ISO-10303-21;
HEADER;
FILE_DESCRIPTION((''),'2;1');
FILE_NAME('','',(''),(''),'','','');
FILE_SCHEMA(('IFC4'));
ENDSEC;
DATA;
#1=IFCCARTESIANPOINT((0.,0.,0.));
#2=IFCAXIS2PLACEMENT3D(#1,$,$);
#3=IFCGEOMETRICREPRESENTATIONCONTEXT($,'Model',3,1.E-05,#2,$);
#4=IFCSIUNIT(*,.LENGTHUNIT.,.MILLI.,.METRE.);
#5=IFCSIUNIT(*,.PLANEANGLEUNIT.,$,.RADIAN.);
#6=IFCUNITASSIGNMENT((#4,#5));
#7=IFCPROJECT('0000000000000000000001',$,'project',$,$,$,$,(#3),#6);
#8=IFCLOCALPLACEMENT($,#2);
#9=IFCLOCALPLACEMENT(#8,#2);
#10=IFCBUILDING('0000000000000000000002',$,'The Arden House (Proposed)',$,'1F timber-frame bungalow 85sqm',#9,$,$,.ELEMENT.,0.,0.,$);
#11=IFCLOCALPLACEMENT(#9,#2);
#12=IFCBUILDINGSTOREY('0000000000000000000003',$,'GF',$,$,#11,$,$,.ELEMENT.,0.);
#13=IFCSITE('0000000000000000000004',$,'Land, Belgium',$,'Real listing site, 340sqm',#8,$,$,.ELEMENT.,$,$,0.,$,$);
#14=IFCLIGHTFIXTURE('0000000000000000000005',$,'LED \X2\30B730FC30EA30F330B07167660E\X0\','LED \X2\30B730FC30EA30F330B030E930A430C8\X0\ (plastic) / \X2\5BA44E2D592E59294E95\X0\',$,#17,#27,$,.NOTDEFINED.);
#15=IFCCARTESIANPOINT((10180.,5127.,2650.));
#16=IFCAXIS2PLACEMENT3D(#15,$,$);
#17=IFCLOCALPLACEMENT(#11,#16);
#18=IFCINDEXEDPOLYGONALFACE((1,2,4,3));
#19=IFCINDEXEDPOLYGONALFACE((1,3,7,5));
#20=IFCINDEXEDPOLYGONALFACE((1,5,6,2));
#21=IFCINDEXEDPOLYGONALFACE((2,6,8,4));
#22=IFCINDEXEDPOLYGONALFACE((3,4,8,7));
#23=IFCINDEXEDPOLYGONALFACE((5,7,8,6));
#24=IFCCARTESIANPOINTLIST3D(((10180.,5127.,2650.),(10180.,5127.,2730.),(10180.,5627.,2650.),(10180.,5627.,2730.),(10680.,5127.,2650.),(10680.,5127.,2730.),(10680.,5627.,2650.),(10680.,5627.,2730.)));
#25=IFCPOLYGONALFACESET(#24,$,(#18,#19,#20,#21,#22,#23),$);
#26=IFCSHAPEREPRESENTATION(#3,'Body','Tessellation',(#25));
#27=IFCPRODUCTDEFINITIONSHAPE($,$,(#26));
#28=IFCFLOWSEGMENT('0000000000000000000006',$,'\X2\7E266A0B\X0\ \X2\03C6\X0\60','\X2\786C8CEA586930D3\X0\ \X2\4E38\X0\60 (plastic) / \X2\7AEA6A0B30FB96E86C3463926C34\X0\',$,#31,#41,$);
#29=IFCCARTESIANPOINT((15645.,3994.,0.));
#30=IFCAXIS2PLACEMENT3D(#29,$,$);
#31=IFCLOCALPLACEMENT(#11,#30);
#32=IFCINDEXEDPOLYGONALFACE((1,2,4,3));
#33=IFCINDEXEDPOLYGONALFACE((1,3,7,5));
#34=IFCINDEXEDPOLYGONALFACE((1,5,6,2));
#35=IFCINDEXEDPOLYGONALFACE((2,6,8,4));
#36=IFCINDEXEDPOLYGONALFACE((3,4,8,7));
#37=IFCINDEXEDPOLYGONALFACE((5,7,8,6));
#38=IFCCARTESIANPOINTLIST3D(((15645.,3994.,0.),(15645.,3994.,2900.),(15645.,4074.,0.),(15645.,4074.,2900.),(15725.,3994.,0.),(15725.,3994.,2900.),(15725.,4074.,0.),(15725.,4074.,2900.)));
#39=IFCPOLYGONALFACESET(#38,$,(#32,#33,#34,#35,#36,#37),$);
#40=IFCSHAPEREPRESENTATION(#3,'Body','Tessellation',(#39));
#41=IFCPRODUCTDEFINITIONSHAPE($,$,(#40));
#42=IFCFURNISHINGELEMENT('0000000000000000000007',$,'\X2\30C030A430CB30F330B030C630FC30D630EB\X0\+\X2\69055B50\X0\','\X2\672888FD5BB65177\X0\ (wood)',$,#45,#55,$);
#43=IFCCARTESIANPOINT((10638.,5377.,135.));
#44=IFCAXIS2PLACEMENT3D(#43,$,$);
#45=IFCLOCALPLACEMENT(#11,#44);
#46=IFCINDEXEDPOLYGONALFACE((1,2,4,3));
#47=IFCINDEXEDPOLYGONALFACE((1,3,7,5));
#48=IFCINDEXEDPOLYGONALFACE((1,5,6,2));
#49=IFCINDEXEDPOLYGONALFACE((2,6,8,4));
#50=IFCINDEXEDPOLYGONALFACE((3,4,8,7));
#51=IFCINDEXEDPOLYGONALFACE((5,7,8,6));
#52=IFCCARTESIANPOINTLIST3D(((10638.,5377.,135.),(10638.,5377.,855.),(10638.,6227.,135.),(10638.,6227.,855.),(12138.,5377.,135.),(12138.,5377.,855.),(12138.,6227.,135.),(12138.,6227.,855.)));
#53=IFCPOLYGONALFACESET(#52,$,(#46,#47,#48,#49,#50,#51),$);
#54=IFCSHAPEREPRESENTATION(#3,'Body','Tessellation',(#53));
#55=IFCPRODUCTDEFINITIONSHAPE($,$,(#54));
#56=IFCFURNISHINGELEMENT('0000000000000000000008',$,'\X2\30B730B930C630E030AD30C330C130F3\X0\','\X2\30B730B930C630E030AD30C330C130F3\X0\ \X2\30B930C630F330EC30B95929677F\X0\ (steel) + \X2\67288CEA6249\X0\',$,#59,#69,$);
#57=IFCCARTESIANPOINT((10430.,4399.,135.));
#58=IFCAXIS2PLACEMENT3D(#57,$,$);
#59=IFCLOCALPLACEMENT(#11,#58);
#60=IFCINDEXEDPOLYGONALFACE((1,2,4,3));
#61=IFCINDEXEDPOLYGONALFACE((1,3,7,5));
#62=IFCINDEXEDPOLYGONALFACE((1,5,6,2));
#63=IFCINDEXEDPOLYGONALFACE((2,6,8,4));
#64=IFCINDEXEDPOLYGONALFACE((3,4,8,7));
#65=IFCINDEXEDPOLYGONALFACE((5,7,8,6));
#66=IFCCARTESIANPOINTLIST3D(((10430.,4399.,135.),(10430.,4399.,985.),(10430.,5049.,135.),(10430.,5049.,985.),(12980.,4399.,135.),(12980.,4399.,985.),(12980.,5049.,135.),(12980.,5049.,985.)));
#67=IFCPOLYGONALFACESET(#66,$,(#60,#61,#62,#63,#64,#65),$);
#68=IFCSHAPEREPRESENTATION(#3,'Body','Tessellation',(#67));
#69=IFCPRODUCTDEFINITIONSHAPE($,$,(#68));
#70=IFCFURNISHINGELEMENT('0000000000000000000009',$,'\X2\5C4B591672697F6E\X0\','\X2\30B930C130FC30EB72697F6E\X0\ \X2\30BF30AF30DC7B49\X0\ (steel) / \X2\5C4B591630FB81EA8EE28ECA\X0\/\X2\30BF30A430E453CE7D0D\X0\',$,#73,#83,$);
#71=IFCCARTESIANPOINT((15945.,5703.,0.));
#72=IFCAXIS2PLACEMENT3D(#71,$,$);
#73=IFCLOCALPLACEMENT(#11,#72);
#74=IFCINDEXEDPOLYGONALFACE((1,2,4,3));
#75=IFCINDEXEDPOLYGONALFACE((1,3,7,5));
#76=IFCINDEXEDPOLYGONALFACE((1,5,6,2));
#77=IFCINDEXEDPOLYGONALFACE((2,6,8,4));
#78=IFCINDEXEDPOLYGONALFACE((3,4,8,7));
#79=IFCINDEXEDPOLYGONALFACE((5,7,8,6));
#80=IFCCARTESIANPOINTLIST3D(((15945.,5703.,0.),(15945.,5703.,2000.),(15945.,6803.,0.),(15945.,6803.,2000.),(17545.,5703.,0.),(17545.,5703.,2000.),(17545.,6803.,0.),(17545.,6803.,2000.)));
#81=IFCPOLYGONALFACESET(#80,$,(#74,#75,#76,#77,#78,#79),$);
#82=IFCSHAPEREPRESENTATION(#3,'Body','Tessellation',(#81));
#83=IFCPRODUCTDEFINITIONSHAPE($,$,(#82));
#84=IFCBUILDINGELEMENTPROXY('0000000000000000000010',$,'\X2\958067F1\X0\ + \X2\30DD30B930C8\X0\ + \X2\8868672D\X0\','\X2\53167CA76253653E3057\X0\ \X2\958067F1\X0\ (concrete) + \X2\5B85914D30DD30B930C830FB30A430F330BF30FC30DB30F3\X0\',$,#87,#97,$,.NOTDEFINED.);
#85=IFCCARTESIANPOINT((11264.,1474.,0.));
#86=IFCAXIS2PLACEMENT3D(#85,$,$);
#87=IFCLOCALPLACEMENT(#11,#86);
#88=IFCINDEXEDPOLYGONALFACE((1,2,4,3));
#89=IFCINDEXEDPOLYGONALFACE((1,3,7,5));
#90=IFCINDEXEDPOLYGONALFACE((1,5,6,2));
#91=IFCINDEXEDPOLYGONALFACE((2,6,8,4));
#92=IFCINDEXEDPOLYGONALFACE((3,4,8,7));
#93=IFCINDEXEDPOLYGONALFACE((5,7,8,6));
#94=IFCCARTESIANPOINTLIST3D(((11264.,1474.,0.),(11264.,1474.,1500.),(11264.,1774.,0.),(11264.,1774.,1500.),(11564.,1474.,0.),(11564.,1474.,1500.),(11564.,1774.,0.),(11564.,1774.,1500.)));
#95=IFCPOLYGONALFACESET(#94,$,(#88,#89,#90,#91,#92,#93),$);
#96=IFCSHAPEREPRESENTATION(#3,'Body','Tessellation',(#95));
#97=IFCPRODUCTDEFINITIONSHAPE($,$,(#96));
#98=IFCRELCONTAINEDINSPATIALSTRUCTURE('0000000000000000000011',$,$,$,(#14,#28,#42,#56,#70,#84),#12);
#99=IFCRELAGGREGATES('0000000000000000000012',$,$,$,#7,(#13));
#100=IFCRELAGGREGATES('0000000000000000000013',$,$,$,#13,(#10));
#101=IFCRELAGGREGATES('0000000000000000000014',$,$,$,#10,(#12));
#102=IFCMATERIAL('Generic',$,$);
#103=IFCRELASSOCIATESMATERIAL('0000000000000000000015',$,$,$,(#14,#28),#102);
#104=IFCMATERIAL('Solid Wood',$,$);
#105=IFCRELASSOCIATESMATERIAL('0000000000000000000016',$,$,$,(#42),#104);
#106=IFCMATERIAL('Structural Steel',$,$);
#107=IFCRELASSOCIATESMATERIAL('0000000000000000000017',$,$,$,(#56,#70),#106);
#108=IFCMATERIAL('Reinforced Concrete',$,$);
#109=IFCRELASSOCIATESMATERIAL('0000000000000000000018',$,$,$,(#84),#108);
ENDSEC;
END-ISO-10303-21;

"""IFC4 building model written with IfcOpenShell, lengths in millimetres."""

from ifc_helpers import new_model, si_unit, frame, frame_2d, origin, place, context, project, spatial, rectangle, extrude, material, element, save


model = new_model("IFC4")

# Units and contexts
model_context = context("Model", 3, precision=1e-05, world=origin())
ifc_project = project(units=[si_unit("LENGTHUNIT", "METRE", prefix="MILLI"), si_unit("PLANEANGLEUNIT", "RADIAN")], contexts=[model_context])

# Site, building, storey
site_placement = place(None, origin())
site = spatial("IfcSite", under=ifc_project, at=site_placement, Name="Land, Belgium", ObjectType="Real listing site, 340sqm", CompositionType="ELEMENT", RefElevation=0.0)
building_placement = place(site_placement, origin())
building = spatial("IfcBuilding", under=site, at=building_placement, Name="The Arden House (Proposed)", ObjectType="1F timber-frame bungalow 85sqm", CompositionType="ELEMENT", ElevationOfRefHeight=0.0, ElevationOfTerrain=0.0)
storey_placement = place(building_placement, origin())
storey = spatial("IfcBuildingStorey", under=building, at=storey_placement, Name="GF", CompositionType="ELEMENT", Elevation=0.0)

# Shared definitions
ifc_material_1 = material(Name="Solid Wood")

# Shared definitions
ifc_material_2 = material(Name="Structural Steel")

# Shared definitions
ifc_material_3 = material(Name="Reinforced Concrete")

# Shared definitions
ifc_material_4 = material(Name="Generic")

# Light fixture
light_fixture_placement = place(storey_placement, frame((10180.0, 5127.0, 2650.0)))
element("IfcLightFixture", 1, at=light_fixture_placement, inside=storey, material=ifc_material_4, Name="LED シーリング照明", Description="LED シーリングライト (plastic) / 室中央天井", PredefinedType="NOTDEFINED", context=model_context, shape_type="SweptSolid", body=[
    extrude(rectangle(XDim=500.0, YDim=500.0, at=frame_2d((250.0, 250.0))), frame((10180.0, 5127.0, 2650.0)), (0.0, 0.0, 1.0), 80.0),
])

# Flow segment
flow_segment_placement = place(storey_placement, frame((15645.0, 3994.0, 0.0)))
element("IfcFlowSegment", 2, at=flow_segment_placement, inside=storey, material=ifc_material_4, Name="縦樋 φ60", Description="硬質塩ビ 丸60 (plastic) / 竪樋・雨水排水", context=model_context, shape_type="SweptSolid", body=[
    extrude(rectangle(XDim=80.0, YDim=80.0, at=frame_2d((40.0, 40.0))), frame((15645.0, 3994.0, 0.0)), (0.0, 0.0, 1.0), 2900.0),
])

# Furnishing elements
furnishing_1_placement = place(storey_placement, frame((10638.0, 5377.0, 135.0)))
element("IfcFurnishingElement", 3, at=furnishing_1_placement, inside=storey, material=ifc_material_1, Name="ダイニングテーブル+椅子", Description="木製家具 (wood)", context=model_context, shape_type="SweptSolid", body=[
    extrude(rectangle(XDim=1500.0, YDim=850.0, at=frame_2d((750.0, 425.0))), frame((10638.0, 5377.0, 135.0)), (0.0, 0.0, 1.0), 720.0),
])
furnishing_2_placement = place(storey_placement, frame((10430.0, 4399.0, 135.0)))
element("IfcFurnishingElement", 4, at=furnishing_2_placement, inside=storey, material=ifc_material_2, Name="システムキッチン", Description="システムキッチン ステンレス天板 (steel) + 木質扉", context=model_context, shape_type="SweptSolid", body=[
    extrude(rectangle(XDim=2550.0, YDim=650.0, at=frame_2d((1275.0, 325.0))), frame((10430.0, 4399.0, 135.0)), (0.0, 0.0, 1.0), 850.0),
])
furnishing_3_placement = place(storey_placement, frame((15945.0, 5703.0, 0.0)))
element("IfcFurnishingElement", 5, at=furnishing_3_placement, inside=storey, material=ifc_material_2, Name="屋外物置", Description="スチール物置 タクボ等 (steel) / 屋外・自転車/タイヤ収納", context=model_context, shape_type="SweptSolid", body=[
    extrude(rectangle(XDim=1600.0, YDim=1100.0, at=frame_2d((800.0, 550.0))), frame((15945.0, 5703.0, 0.0)), (0.0, 0.0, 1.0), 2000.0),
])

# Building element proxy
proxy_placement = place(storey_placement, frame((11264.0, 1474.0, 0.0)))
element("IfcBuildingElementProxy", 6, at=proxy_placement, inside=storey, material=ifc_material_3, Name="門柱 + ポスト + 表札", Description="化粧打放し 門柱 (concrete) + 宅配ポスト・インターホン", PredefinedType="NOTDEFINED", context=model_context, shape_type="SweptSolid", body=[
    extrude(rectangle(XDim=300.0, YDim=300.0, at=frame_2d((150.0, 150.0))), frame((11264.0, 1474.0, 0.0)), (0.0, 0.0, 1.0), 1500.0),
])

save(model, "model.ifc")
